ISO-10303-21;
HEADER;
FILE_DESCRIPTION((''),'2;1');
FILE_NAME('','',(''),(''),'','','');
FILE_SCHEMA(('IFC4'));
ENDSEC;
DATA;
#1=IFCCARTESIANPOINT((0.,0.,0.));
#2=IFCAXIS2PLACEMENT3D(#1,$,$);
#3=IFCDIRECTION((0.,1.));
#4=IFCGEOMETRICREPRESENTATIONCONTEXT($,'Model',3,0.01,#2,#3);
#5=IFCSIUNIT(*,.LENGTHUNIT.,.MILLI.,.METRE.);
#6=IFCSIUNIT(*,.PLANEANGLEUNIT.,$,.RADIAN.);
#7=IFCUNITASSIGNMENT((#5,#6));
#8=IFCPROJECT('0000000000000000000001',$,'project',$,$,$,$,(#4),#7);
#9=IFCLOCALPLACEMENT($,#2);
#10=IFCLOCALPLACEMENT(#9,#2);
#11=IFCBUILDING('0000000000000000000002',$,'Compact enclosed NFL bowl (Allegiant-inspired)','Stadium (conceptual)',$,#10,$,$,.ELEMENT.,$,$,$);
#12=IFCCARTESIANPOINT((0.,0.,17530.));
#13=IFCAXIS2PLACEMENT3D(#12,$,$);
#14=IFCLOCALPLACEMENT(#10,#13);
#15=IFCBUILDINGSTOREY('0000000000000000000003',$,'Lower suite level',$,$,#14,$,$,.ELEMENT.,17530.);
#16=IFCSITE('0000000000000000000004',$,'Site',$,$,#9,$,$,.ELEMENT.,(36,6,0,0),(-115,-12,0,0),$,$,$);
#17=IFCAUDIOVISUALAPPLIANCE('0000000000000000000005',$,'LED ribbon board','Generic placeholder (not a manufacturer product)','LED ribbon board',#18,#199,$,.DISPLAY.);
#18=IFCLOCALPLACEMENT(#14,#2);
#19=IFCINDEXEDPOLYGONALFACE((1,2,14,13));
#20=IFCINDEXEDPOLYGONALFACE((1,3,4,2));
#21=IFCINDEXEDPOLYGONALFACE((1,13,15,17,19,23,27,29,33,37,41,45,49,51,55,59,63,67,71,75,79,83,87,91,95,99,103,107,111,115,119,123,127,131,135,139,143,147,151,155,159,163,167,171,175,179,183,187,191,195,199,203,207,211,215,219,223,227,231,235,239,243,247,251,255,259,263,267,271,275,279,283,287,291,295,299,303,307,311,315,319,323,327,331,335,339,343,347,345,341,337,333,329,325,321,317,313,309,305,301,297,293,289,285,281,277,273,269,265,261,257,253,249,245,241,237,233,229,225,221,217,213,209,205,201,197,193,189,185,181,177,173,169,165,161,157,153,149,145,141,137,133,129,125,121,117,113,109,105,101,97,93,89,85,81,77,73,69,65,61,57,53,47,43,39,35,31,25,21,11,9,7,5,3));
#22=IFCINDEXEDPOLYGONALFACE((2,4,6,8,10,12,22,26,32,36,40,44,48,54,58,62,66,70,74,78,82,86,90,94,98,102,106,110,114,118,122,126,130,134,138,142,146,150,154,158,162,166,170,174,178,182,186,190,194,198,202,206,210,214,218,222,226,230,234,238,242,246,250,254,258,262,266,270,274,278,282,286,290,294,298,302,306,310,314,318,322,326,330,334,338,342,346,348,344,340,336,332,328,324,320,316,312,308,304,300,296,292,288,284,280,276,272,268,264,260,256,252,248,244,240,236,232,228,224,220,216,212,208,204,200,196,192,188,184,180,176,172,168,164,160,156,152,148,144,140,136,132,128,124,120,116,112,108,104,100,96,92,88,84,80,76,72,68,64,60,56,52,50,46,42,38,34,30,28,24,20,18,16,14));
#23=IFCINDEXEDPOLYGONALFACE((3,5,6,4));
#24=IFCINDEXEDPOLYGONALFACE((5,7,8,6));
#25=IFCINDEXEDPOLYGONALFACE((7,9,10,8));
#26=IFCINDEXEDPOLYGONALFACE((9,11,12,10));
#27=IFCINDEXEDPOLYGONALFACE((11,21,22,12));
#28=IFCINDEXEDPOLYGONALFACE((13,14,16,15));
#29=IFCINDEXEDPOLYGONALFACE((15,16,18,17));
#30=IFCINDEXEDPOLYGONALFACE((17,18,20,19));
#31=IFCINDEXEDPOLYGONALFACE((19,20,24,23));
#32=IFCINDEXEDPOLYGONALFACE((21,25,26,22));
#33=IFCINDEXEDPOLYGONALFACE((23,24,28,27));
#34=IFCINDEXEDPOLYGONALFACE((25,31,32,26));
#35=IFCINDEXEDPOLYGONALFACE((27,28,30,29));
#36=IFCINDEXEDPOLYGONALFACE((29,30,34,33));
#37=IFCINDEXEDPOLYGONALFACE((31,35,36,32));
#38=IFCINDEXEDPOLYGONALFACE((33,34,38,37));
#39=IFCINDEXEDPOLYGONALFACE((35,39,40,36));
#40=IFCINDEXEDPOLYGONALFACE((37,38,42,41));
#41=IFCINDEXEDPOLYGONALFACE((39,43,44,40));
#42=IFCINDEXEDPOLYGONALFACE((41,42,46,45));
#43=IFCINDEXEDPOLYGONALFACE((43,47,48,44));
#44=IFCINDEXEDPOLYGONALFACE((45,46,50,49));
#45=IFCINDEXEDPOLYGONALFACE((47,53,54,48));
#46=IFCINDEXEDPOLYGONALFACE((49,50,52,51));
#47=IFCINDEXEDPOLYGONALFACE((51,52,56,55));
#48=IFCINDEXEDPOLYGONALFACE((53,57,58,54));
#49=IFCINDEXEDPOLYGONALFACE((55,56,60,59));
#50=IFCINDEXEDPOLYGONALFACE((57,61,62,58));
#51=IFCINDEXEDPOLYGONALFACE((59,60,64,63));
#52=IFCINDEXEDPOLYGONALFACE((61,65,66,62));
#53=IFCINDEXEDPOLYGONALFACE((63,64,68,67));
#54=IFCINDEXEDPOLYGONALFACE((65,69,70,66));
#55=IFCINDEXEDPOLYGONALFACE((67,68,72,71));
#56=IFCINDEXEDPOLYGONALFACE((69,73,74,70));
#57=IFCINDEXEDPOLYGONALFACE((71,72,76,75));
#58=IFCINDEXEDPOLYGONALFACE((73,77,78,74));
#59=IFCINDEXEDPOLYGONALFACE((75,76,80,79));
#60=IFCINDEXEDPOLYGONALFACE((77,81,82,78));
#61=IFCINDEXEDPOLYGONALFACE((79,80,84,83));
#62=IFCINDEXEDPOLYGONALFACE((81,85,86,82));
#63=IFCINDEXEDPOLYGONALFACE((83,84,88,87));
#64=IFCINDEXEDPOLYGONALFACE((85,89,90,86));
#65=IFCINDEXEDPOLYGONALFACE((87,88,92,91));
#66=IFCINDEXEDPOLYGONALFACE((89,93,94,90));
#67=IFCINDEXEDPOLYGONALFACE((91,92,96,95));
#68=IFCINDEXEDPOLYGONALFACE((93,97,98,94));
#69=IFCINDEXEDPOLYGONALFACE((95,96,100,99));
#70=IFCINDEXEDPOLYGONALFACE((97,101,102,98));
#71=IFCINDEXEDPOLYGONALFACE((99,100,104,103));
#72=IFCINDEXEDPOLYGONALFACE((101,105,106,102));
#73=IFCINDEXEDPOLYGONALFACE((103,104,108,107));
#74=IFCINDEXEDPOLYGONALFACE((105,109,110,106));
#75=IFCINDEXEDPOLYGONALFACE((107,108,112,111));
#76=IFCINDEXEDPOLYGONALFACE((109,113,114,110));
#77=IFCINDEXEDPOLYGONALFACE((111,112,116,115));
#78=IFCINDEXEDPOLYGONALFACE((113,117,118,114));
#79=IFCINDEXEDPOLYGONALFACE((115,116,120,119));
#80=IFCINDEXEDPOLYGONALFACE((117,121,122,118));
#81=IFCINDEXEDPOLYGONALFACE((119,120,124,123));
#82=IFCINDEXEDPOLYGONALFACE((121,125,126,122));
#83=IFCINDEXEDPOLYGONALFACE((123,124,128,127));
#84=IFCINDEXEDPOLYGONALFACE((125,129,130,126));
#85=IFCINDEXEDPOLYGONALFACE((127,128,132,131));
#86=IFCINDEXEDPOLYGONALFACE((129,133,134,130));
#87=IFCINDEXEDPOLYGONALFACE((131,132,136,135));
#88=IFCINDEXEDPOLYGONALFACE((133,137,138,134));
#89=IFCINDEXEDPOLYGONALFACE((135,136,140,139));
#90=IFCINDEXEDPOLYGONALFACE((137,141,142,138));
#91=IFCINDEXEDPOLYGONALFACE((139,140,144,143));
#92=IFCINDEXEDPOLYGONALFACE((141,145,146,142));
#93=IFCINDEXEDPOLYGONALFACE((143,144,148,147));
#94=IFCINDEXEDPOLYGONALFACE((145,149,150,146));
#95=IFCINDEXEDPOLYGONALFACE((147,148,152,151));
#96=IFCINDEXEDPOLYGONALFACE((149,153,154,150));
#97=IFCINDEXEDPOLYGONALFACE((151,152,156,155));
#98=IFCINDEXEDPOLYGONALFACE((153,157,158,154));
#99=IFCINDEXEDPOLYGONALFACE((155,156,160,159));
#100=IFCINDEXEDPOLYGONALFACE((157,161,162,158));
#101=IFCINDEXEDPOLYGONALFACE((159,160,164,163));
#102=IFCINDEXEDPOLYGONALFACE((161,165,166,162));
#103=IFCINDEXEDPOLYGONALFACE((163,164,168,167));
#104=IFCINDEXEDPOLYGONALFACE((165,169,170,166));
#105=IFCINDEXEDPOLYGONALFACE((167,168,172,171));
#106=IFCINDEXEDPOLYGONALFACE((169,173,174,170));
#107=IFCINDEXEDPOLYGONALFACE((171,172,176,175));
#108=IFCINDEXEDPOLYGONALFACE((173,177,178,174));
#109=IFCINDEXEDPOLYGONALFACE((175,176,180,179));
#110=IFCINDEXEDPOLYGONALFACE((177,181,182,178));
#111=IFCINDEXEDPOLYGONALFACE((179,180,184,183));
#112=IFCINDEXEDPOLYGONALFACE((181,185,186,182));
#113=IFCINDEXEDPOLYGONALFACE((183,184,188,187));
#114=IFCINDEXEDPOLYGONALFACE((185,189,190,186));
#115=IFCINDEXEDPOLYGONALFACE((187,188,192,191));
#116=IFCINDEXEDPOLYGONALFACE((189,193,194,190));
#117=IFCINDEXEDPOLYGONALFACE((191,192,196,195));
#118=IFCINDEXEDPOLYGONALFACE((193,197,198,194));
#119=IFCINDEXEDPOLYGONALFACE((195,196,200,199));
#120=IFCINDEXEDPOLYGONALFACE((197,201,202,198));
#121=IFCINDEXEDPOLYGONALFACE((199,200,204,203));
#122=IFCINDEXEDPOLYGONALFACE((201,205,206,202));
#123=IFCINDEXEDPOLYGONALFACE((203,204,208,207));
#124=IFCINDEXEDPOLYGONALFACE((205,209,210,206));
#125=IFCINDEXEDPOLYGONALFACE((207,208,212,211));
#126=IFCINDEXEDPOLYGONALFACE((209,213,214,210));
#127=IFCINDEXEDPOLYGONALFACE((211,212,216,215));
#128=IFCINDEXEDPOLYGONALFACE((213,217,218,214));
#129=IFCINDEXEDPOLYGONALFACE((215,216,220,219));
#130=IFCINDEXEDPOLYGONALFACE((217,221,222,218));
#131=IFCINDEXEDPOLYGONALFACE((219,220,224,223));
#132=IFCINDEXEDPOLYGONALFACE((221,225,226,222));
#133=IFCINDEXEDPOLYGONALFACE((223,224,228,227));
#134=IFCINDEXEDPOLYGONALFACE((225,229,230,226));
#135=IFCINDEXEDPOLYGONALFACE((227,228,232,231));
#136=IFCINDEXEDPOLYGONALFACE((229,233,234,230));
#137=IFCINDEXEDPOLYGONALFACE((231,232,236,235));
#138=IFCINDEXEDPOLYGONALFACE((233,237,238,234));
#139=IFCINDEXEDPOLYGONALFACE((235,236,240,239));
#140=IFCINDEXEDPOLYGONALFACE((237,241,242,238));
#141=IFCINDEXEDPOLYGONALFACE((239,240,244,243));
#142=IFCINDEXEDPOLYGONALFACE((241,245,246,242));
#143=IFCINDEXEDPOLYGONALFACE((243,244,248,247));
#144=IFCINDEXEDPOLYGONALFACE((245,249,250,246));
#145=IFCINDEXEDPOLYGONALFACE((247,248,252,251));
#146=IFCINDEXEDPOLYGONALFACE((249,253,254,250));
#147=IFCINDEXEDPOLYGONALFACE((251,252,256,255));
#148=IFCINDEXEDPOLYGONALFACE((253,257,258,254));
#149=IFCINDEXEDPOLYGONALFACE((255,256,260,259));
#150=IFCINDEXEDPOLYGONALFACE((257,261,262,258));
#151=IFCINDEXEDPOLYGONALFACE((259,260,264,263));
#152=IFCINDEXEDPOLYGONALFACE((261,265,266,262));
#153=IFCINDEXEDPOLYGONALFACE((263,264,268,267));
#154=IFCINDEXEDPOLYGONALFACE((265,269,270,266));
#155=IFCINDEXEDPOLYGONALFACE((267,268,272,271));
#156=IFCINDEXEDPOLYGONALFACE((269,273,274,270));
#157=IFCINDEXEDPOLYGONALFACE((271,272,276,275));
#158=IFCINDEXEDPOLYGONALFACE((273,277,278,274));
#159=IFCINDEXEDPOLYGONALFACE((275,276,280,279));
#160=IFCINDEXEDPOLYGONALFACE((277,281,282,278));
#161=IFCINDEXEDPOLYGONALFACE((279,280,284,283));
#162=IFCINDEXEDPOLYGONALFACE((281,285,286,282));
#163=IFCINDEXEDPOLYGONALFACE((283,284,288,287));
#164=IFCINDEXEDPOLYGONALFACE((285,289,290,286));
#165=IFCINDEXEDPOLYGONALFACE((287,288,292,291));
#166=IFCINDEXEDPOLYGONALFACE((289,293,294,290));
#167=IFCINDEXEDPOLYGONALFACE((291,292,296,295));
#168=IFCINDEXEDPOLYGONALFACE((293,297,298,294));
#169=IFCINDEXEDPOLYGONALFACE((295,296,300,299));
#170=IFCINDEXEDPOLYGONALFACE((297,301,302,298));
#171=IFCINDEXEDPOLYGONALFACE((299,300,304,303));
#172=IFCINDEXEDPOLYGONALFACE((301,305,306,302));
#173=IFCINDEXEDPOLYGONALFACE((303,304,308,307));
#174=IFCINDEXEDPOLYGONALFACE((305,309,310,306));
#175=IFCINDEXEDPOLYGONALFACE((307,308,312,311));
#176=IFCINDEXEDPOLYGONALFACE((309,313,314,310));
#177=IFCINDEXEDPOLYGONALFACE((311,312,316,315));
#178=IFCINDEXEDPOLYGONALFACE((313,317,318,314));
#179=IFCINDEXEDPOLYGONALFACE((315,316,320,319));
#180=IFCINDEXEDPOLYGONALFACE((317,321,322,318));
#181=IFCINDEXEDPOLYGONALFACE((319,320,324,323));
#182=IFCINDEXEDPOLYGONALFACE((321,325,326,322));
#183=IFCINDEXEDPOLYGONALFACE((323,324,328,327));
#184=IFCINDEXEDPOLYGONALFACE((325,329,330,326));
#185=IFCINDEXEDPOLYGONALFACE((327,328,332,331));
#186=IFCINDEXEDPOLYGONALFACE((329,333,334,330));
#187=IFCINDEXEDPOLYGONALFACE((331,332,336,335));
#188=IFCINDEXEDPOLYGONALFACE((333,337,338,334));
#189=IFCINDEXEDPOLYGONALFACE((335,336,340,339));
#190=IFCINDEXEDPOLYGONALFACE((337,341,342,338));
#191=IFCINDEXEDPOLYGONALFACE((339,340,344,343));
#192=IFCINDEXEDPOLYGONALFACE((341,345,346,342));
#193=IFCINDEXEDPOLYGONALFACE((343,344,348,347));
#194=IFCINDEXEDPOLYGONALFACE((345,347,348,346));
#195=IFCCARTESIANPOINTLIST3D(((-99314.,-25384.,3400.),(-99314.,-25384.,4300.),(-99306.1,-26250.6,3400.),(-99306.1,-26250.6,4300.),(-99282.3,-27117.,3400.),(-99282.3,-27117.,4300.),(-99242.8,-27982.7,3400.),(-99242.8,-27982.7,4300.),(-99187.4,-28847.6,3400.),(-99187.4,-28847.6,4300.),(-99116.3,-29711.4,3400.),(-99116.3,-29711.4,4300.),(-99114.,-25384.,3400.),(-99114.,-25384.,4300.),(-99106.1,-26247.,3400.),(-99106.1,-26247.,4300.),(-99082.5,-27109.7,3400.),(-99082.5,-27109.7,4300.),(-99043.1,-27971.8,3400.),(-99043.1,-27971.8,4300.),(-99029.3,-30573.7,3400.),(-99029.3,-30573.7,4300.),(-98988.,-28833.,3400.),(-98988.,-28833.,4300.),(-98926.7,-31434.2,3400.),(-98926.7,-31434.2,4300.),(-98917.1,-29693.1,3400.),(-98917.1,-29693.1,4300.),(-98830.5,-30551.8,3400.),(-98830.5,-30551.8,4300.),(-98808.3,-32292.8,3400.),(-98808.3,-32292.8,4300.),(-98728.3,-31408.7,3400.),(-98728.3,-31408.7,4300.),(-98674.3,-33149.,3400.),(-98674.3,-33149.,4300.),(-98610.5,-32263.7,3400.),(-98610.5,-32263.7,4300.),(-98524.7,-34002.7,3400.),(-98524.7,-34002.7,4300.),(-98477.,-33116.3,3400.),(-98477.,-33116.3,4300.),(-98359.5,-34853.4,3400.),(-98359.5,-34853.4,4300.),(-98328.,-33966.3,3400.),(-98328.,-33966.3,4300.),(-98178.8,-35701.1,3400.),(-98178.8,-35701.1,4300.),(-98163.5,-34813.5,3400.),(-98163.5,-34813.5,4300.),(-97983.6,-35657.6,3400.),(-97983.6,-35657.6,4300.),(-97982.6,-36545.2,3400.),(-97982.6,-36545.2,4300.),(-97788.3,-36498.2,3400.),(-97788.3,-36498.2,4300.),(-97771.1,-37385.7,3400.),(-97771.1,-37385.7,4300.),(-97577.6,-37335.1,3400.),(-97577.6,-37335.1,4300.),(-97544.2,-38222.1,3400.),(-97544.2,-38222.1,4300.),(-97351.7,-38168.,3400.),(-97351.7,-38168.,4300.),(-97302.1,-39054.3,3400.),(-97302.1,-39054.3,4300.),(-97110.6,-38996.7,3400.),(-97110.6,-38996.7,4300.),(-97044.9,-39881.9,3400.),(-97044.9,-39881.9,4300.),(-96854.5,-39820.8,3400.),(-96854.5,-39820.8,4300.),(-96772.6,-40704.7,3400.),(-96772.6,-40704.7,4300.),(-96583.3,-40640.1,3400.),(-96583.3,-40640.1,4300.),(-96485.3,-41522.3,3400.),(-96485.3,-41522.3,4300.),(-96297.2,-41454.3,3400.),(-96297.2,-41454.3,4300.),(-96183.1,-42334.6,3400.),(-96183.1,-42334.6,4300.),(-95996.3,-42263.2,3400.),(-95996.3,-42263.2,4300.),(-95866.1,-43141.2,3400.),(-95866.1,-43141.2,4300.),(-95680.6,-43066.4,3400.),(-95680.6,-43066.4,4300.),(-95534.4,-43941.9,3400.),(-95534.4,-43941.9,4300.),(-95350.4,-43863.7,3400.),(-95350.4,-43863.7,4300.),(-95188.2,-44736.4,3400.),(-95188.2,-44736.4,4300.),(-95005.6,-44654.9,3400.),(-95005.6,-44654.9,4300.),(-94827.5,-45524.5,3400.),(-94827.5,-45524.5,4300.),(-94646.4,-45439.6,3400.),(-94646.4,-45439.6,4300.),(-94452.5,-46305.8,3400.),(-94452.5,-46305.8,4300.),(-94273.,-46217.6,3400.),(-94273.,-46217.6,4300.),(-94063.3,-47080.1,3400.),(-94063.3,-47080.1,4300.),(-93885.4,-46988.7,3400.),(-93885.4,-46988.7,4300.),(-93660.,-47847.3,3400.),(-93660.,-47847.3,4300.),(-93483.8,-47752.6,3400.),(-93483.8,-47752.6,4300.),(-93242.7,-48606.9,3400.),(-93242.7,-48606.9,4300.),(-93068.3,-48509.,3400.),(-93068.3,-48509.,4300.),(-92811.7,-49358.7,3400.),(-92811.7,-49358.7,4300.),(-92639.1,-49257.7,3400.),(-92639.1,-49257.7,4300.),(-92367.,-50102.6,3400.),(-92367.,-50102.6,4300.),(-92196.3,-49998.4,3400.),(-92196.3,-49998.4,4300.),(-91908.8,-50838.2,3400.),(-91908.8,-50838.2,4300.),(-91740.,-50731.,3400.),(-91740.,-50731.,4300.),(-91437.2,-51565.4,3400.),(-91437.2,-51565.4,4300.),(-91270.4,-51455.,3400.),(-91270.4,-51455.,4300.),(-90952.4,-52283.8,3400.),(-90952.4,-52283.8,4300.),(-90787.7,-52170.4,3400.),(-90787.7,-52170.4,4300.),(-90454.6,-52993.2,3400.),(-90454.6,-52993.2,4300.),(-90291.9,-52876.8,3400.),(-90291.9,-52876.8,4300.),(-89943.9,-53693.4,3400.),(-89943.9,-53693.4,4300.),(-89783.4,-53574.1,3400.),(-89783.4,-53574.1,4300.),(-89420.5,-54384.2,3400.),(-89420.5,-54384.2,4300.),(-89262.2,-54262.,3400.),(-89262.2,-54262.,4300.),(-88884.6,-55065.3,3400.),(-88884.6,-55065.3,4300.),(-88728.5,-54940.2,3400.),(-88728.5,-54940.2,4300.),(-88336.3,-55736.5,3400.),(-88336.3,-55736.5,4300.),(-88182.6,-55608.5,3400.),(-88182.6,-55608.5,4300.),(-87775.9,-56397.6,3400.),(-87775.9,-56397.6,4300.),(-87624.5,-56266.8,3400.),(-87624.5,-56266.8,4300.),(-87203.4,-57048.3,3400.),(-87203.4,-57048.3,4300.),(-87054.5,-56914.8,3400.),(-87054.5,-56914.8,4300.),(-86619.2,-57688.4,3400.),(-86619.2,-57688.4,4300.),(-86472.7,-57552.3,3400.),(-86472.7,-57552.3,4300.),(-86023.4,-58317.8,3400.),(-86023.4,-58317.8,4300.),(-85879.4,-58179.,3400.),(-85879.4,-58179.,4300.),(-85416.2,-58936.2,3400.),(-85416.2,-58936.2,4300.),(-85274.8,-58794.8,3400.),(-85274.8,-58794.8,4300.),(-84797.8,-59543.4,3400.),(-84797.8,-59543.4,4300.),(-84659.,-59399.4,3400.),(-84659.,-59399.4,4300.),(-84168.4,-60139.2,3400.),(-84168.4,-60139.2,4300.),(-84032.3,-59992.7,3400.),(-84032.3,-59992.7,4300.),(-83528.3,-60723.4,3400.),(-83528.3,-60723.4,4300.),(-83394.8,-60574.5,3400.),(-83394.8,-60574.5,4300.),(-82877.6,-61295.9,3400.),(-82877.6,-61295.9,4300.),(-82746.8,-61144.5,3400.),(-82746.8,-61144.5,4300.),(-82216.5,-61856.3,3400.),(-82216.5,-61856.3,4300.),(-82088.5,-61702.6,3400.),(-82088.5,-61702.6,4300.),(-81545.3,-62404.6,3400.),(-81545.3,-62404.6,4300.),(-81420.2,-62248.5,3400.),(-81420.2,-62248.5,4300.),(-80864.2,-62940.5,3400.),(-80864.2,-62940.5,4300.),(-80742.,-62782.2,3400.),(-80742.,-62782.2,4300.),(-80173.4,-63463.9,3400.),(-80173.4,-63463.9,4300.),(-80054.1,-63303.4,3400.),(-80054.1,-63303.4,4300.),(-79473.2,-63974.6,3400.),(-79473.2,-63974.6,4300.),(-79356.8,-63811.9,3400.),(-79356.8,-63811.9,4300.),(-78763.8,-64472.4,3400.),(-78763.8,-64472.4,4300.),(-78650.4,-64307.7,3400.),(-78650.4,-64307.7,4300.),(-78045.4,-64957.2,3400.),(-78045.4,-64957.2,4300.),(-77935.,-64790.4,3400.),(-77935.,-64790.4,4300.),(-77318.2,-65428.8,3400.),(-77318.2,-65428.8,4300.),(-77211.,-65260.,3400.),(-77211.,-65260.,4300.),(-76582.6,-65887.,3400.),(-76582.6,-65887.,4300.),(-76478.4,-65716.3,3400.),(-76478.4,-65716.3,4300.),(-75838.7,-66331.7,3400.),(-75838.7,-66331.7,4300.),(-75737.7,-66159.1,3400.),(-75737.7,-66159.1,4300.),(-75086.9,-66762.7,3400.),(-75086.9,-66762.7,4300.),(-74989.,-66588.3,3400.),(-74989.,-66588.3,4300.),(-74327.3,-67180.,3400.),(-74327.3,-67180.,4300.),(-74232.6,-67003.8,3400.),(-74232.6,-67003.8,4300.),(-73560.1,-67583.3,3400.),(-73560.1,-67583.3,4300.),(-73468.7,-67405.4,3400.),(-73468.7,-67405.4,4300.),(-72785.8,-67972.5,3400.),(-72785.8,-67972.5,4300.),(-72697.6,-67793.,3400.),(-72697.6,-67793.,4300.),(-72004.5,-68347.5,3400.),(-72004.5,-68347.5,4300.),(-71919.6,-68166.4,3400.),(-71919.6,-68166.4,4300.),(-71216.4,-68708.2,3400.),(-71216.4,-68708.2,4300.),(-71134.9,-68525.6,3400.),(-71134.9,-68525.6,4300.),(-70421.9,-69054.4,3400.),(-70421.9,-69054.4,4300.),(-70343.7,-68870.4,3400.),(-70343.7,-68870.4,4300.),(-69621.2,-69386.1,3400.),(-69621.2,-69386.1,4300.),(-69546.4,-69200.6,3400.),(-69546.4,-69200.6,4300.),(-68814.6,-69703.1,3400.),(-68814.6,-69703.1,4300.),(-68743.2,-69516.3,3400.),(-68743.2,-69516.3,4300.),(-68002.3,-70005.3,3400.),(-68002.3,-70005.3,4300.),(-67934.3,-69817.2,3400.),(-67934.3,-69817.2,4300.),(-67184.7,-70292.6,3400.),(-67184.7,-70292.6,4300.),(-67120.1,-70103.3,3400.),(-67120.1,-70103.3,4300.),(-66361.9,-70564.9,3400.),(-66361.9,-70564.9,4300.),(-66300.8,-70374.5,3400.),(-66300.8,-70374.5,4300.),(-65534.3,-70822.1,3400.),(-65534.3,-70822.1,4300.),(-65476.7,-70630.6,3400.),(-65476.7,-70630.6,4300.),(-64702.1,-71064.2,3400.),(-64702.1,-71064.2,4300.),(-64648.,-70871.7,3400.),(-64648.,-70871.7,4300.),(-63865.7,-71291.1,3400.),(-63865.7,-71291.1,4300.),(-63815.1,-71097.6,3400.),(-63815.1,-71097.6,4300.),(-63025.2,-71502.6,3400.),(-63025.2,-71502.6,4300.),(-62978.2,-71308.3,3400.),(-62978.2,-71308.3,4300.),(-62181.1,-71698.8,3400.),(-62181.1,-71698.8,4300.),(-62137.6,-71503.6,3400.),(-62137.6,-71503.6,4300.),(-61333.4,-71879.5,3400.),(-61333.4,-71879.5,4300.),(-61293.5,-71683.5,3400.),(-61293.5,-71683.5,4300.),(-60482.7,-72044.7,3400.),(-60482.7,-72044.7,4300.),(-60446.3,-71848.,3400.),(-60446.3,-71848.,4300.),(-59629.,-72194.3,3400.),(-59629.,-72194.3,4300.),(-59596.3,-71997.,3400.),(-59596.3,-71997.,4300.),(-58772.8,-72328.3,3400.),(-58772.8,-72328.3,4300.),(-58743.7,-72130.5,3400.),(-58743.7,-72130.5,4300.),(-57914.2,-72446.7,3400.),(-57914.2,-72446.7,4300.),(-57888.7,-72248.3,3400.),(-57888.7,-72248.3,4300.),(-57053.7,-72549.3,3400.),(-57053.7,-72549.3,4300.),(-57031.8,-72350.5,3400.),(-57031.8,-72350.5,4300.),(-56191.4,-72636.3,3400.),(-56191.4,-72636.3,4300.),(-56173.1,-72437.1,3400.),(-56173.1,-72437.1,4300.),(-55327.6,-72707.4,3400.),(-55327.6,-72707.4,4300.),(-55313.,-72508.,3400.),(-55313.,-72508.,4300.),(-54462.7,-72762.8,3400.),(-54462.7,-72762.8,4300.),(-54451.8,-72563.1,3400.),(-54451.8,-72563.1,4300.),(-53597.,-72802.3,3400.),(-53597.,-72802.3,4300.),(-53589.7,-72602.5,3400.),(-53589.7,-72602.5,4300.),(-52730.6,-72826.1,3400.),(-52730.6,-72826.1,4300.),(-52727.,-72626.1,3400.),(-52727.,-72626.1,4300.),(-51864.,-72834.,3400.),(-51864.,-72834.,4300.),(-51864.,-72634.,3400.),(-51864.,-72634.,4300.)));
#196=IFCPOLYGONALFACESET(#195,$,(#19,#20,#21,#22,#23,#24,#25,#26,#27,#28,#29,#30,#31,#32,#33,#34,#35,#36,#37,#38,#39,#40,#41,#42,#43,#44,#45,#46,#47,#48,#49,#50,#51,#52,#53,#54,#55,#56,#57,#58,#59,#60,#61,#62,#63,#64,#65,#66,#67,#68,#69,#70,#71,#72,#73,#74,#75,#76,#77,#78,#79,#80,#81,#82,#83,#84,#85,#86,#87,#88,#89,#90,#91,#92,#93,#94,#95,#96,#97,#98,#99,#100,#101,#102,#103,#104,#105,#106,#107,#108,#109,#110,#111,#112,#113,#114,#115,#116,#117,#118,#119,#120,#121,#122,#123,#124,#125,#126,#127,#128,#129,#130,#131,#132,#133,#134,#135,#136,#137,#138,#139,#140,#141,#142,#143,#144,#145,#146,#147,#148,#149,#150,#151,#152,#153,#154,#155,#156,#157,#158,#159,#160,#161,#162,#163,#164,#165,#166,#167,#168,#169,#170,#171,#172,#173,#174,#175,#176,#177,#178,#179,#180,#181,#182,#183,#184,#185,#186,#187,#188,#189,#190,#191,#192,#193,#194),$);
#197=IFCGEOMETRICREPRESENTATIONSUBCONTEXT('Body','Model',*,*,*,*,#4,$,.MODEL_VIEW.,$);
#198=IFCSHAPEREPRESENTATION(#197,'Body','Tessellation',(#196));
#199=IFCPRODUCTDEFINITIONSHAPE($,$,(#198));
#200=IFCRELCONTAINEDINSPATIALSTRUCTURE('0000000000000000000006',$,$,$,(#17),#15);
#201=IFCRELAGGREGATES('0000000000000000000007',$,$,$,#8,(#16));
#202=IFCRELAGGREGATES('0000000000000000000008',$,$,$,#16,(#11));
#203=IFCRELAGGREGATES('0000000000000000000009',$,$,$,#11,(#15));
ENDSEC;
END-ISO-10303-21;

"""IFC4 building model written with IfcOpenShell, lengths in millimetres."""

from ifc_helpers import new_model, si_unit, direction, frame, origin, place, context, subcontext, project, spatial, line, arc, indexed_curve, outline, extrude, element, save


model = new_model("IFC4")

# Units and contexts
model_context = context("Model", 3, precision=0.01, world=origin(), true_north=direction((0.0, 1.0)))
body_context = subcontext(model_context, "Body", "Model", "MODEL_VIEW")
ifc_project = project(units=[si_unit("LENGTHUNIT", "METRE", prefix="MILLI"), si_unit("PLANEANGLEUNIT", "RADIAN")], contexts=[model_context])

# Site, building, storey
site_placement = place(None, origin())
site = spatial("IfcSite", under=ifc_project, at=site_placement, Name="Site", CompositionType="ELEMENT", RefLatitude=(36, 6, 0, 0), RefLongitude=(-115, -12, 0, 0))
building_placement = place(site_placement, origin())
building = spatial("IfcBuilding", under=site, at=building_placement, Name="Compact enclosed NFL bowl (Allegiant-inspired)", Description="Stadium (conceptual)", CompositionType="ELEMENT")
storey_placement = place(building_placement, frame((0.0, 0.0, 17530.0)))
storey = spatial("IfcBuildingStorey", under=building, at=storey_placement, Name="Lower suite level", CompositionType="ELEMENT", Elevation=17530.0)

# Shared definitions
placement = place(storey_placement, frame((0.0, 0.0, -17530.0)))

# Audio visual appliance
element("IfcAudioVisualAppliance", 1, at=placement, inside=storey, Name="LED ribbon board", Description="Generic placeholder (not a manufacturer product)", ObjectType="LED ribbon board", PredefinedType="DISPLAY", context=body_context, shape_type="SweptSolid", body=[
    extrude(outline(indexed_curve([(-99114.0, -25384.0), (-85274.8, -58794.8), (-51864.0, -72634.0), (-51864.0, -72834.0), (-85416.2, -58936.2), (-99314.0, -25384.0)], segments=[arc(1, 2, 3), line(3, 4), arc(4, 5, 6), line(6, 1)], self_intersect=False)), frame((0.0, 0.0, 20930.0)), (0.0, 0.0, 1.0), 900.0),
])

save(model, "model.ifc")
